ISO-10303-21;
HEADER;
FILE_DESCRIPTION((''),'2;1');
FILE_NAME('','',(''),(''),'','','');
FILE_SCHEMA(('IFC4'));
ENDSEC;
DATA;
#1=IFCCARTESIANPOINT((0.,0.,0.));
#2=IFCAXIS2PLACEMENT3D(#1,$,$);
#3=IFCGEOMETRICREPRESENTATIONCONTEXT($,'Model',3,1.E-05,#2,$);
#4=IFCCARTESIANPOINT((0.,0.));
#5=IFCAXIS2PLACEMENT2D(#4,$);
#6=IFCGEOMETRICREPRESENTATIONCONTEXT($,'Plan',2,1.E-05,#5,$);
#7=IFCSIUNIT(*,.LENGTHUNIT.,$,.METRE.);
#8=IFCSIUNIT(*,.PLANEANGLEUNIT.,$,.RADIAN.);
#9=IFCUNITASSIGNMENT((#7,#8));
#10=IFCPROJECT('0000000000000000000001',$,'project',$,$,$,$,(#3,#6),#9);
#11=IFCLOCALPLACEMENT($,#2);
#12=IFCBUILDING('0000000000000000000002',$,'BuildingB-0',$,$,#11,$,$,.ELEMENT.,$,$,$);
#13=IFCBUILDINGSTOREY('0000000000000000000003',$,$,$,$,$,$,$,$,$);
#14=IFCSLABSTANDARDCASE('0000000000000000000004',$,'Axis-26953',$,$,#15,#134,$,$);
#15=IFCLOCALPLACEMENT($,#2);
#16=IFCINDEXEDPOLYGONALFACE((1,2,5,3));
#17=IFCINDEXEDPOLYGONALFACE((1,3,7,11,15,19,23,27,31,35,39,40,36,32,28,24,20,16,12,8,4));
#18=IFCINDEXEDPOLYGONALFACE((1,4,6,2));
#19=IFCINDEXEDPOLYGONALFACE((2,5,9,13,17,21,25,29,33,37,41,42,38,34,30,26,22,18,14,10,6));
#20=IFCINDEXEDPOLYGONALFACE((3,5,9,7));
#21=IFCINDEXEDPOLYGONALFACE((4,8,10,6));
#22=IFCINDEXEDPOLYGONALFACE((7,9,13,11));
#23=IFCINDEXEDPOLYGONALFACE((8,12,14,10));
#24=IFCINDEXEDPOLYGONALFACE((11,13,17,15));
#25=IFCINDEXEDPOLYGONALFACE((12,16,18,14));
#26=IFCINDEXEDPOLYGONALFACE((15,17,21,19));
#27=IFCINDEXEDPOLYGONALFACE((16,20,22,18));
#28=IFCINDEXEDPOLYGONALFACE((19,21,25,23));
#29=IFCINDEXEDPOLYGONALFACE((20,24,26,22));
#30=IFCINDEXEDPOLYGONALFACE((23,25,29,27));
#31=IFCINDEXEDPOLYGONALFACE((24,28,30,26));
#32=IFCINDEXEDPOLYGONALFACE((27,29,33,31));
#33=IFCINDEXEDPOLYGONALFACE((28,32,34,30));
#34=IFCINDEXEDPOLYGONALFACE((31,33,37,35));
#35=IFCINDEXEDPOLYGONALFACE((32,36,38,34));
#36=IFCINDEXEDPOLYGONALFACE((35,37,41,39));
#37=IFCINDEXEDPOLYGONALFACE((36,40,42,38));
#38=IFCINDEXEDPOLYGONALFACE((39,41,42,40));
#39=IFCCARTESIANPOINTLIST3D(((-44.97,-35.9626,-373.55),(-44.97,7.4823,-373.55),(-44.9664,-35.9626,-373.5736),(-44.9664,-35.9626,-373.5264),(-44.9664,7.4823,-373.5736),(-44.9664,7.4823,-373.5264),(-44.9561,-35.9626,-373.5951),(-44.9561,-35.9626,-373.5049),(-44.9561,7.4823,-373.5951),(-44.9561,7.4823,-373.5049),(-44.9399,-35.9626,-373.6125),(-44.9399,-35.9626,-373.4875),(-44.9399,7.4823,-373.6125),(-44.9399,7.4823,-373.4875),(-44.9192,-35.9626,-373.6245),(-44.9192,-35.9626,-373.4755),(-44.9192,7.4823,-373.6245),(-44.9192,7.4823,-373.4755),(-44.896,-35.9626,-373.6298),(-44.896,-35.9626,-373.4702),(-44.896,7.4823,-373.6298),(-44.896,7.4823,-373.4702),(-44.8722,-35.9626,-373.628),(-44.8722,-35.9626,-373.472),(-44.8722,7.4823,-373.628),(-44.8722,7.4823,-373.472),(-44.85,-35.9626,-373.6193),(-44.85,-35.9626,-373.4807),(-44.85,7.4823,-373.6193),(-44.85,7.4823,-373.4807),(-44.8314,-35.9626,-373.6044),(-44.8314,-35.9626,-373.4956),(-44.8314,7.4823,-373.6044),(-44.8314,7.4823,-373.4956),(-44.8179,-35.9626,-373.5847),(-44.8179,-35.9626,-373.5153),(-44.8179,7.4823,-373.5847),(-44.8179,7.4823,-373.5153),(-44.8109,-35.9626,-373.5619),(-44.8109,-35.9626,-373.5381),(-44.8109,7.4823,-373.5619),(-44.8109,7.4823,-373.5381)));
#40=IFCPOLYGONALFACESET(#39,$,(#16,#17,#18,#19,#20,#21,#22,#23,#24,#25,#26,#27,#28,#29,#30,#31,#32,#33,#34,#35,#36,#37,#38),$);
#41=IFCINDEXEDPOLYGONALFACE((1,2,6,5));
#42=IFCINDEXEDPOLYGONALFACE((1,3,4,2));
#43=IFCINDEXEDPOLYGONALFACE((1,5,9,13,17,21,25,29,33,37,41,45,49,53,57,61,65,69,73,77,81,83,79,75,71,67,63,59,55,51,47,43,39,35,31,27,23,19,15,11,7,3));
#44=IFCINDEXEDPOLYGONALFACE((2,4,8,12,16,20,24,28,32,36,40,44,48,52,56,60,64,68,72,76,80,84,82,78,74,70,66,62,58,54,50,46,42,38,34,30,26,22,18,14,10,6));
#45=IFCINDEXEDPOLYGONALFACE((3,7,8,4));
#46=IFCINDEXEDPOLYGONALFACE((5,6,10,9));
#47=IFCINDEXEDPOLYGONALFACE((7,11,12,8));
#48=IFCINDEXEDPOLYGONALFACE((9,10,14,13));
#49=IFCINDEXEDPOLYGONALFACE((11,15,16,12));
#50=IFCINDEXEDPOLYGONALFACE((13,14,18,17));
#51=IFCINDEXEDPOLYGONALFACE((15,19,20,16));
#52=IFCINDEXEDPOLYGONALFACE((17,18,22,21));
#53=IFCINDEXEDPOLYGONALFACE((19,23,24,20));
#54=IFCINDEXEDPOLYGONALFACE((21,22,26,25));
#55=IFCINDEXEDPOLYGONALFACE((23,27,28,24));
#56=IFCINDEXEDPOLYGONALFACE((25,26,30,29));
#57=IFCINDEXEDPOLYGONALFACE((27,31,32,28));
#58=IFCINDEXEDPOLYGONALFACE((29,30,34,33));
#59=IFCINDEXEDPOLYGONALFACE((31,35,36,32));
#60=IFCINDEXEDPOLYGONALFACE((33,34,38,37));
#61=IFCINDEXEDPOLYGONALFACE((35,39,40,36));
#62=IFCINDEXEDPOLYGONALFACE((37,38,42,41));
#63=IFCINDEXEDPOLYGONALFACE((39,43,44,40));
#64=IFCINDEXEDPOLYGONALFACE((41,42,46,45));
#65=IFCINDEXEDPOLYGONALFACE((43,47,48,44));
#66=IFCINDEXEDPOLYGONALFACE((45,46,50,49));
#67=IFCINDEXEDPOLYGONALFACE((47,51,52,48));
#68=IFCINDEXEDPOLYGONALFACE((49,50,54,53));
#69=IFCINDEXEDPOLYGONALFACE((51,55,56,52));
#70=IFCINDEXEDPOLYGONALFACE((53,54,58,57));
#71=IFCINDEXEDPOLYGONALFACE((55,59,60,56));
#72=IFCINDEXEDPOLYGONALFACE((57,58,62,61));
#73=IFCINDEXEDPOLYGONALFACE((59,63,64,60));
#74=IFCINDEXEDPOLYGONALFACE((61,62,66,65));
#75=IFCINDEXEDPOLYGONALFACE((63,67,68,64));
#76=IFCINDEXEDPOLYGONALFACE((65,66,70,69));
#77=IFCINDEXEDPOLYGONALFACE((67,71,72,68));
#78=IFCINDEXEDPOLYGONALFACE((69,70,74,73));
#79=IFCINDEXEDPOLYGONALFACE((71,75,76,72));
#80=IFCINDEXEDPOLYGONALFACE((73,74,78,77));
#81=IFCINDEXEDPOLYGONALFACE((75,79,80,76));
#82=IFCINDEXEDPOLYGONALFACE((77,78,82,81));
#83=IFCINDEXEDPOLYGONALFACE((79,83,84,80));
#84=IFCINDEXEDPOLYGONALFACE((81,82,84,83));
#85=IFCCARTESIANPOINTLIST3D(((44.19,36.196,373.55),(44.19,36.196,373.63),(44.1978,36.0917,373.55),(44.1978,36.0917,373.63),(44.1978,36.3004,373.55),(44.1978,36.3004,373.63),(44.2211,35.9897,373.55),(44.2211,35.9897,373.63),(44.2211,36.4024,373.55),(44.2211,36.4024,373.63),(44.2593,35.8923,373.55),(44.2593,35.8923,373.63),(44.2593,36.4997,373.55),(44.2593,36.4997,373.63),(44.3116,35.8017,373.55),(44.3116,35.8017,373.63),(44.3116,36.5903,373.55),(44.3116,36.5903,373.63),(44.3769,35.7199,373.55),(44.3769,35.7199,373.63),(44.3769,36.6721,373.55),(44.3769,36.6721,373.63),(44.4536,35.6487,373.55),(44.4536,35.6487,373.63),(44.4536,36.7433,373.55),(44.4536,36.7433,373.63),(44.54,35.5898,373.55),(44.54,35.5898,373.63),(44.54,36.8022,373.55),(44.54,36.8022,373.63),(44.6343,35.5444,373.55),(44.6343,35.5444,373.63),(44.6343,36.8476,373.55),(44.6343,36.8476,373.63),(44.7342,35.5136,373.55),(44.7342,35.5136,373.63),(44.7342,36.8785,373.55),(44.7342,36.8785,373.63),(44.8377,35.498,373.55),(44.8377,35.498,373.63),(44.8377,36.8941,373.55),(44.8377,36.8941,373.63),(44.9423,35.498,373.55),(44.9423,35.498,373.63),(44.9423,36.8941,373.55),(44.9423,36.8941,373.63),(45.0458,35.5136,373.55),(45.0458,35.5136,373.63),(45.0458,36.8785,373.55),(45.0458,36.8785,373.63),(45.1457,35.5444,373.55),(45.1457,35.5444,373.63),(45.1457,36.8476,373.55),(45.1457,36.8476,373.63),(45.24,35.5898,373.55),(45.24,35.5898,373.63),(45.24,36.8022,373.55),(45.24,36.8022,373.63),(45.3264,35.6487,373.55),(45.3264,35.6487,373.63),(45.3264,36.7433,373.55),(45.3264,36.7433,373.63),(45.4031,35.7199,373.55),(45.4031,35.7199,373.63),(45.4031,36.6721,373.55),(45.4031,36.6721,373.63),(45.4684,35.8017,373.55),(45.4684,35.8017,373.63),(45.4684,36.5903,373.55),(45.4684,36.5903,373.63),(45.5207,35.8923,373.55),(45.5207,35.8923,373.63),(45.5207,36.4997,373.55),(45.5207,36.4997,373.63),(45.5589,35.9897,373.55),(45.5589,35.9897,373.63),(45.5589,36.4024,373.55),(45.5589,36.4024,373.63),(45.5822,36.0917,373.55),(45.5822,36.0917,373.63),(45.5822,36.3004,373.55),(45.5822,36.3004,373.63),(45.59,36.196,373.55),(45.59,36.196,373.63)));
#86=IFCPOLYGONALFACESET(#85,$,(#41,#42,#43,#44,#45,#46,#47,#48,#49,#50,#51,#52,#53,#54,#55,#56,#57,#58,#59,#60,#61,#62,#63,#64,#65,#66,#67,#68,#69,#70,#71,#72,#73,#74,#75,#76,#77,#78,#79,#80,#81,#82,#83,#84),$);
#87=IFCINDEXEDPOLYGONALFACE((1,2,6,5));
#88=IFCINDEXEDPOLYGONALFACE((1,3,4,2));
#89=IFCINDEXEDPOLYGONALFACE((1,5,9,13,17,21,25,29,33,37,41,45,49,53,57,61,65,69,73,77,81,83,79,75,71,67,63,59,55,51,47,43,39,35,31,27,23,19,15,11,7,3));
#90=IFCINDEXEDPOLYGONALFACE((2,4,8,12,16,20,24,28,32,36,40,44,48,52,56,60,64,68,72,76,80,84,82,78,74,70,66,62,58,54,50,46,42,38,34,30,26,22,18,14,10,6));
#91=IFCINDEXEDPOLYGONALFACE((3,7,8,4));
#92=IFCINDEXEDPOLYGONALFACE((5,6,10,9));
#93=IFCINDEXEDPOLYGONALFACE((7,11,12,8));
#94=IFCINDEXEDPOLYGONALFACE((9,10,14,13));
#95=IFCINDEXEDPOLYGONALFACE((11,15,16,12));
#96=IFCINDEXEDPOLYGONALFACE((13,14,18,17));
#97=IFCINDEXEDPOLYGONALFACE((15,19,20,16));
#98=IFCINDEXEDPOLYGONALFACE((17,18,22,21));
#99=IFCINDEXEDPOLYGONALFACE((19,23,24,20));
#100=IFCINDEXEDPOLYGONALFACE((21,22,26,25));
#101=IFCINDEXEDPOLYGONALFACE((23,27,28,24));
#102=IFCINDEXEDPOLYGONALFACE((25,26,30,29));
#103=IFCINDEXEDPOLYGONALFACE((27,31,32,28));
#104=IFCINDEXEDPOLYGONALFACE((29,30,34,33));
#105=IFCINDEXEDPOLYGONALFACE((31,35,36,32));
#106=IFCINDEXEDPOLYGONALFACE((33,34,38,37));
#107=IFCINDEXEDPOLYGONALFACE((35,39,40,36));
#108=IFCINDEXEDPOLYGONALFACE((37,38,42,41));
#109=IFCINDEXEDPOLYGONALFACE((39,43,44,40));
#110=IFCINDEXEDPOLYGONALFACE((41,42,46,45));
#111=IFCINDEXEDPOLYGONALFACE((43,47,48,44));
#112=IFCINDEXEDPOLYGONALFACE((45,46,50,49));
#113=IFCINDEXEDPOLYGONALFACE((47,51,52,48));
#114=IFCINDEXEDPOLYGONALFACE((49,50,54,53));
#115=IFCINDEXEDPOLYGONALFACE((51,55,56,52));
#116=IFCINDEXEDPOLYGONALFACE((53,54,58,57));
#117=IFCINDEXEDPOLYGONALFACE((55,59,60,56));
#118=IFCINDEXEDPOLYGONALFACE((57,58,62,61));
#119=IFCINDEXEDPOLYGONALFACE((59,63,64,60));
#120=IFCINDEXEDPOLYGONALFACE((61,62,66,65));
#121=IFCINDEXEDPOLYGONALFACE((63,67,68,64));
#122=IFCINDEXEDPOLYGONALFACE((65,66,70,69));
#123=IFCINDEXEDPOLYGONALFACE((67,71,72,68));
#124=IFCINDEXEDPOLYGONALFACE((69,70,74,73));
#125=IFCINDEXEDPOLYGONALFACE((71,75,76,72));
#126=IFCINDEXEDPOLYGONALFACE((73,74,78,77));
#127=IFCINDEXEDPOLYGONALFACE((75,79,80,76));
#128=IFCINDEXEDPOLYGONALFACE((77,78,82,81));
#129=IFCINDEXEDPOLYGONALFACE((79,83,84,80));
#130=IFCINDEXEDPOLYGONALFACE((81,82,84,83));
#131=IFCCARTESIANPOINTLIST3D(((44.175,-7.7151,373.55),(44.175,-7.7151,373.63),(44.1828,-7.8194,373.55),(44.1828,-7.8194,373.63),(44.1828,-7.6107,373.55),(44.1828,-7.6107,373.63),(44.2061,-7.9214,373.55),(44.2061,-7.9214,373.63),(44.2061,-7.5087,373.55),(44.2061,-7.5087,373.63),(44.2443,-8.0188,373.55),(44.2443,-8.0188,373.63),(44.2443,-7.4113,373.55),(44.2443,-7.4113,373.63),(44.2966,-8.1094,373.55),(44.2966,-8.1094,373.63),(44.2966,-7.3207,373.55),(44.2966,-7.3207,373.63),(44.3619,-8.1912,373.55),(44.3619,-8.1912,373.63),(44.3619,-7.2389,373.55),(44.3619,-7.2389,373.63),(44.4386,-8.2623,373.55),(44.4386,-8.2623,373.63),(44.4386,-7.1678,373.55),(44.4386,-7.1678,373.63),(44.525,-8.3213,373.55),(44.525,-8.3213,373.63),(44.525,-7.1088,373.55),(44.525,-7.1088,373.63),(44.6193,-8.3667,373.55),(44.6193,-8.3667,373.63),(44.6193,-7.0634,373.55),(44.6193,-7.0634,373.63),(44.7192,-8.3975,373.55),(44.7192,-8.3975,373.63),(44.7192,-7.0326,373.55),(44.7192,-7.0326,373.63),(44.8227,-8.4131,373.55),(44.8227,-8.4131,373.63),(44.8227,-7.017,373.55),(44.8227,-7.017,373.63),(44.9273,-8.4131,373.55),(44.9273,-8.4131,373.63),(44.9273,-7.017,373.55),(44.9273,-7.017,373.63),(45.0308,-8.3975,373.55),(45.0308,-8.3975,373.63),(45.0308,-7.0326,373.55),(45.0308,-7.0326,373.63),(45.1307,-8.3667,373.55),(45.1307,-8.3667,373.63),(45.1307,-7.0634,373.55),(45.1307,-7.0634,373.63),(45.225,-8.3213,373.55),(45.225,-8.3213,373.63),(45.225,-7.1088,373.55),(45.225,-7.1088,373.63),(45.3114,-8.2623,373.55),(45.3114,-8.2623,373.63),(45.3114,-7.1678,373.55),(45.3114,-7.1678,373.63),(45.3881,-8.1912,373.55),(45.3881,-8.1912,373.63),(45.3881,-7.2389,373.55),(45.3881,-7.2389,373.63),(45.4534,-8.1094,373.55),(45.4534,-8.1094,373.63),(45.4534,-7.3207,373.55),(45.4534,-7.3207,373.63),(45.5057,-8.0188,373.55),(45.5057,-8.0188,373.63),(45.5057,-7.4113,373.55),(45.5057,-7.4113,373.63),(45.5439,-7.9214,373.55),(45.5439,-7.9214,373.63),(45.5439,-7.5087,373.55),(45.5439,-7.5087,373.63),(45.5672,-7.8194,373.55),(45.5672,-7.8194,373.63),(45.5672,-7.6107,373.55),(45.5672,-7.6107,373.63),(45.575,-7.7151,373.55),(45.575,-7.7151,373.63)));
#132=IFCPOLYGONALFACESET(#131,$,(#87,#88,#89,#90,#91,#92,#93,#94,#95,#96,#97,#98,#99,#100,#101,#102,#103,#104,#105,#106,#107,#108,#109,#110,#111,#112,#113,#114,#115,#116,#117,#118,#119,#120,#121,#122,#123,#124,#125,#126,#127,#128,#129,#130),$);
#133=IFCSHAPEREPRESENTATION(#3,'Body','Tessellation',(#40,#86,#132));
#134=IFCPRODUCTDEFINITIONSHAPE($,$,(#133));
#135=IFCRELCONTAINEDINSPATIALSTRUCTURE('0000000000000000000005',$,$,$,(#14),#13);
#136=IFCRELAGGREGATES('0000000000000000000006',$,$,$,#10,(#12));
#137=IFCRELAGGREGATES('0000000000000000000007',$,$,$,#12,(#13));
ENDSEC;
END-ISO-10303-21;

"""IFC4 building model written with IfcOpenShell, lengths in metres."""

from ifc_helpers import new_model, entity, si_unit, frame, origin, origin_2d, place, context, project, spatial, circle, extrude, element, save


model = new_model("IFC4")

# Units and contexts
model_context = context("Model", 3, precision=1e-05, world=origin())
plan_context = context("Plan", 2, precision=1e-05, world=origin_2d())
ifc_project = project(units=[si_unit("LENGTHUNIT", "METRE"), si_unit("PLANEANGLEUNIT", "RADIAN")], contexts=[model_context, plan_context])

# Building, storey
building_placement = place(None, origin())
building = spatial("IfcBuilding", under=ifc_project, at=building_placement, Name="BuildingB-0", CompositionType="ELEMENT")
storey = spatial("IfcBuildingStorey", under=building)

# Slab
element("IfcSlabStandardCase", 1, inside=storey, Name="Axis-26953", context=model_context, shape_type="AdvancedSweptSolid", body=[
    entity("IfcSurfaceCurveSweptAreaSolid", entity("IfcCircleProfileDef", "AREA", None, None, 0.08), None, entity("IfcPolyline", [entity("IfcCartesianPoint", [44.89, 35.9626, 373.55]), entity("IfcCartesianPoint", [44.89, -7.4823, 373.55])]), None, None, entity("IfcPlane", entity("IfcAxis2Placement3D", entity("IfcCartesianPoint", [44.89, 35.9626, 373.55]), entity("IfcDirection", [0.0, 0.0, 1.0]), entity("IfcDirection", [1.0, 0.0, 0.0])))),
    extrude(circle(Radius=0.7), frame((44.89, 36.196, 373.55)), (0.0, 0.0, 1.0), 0.08),
    extrude(circle(Radius=0.7), frame((44.875, -7.7151, 373.55)), (0.0, 0.0, 1.0), 0.08),
])

save(model, "model.ifc")
